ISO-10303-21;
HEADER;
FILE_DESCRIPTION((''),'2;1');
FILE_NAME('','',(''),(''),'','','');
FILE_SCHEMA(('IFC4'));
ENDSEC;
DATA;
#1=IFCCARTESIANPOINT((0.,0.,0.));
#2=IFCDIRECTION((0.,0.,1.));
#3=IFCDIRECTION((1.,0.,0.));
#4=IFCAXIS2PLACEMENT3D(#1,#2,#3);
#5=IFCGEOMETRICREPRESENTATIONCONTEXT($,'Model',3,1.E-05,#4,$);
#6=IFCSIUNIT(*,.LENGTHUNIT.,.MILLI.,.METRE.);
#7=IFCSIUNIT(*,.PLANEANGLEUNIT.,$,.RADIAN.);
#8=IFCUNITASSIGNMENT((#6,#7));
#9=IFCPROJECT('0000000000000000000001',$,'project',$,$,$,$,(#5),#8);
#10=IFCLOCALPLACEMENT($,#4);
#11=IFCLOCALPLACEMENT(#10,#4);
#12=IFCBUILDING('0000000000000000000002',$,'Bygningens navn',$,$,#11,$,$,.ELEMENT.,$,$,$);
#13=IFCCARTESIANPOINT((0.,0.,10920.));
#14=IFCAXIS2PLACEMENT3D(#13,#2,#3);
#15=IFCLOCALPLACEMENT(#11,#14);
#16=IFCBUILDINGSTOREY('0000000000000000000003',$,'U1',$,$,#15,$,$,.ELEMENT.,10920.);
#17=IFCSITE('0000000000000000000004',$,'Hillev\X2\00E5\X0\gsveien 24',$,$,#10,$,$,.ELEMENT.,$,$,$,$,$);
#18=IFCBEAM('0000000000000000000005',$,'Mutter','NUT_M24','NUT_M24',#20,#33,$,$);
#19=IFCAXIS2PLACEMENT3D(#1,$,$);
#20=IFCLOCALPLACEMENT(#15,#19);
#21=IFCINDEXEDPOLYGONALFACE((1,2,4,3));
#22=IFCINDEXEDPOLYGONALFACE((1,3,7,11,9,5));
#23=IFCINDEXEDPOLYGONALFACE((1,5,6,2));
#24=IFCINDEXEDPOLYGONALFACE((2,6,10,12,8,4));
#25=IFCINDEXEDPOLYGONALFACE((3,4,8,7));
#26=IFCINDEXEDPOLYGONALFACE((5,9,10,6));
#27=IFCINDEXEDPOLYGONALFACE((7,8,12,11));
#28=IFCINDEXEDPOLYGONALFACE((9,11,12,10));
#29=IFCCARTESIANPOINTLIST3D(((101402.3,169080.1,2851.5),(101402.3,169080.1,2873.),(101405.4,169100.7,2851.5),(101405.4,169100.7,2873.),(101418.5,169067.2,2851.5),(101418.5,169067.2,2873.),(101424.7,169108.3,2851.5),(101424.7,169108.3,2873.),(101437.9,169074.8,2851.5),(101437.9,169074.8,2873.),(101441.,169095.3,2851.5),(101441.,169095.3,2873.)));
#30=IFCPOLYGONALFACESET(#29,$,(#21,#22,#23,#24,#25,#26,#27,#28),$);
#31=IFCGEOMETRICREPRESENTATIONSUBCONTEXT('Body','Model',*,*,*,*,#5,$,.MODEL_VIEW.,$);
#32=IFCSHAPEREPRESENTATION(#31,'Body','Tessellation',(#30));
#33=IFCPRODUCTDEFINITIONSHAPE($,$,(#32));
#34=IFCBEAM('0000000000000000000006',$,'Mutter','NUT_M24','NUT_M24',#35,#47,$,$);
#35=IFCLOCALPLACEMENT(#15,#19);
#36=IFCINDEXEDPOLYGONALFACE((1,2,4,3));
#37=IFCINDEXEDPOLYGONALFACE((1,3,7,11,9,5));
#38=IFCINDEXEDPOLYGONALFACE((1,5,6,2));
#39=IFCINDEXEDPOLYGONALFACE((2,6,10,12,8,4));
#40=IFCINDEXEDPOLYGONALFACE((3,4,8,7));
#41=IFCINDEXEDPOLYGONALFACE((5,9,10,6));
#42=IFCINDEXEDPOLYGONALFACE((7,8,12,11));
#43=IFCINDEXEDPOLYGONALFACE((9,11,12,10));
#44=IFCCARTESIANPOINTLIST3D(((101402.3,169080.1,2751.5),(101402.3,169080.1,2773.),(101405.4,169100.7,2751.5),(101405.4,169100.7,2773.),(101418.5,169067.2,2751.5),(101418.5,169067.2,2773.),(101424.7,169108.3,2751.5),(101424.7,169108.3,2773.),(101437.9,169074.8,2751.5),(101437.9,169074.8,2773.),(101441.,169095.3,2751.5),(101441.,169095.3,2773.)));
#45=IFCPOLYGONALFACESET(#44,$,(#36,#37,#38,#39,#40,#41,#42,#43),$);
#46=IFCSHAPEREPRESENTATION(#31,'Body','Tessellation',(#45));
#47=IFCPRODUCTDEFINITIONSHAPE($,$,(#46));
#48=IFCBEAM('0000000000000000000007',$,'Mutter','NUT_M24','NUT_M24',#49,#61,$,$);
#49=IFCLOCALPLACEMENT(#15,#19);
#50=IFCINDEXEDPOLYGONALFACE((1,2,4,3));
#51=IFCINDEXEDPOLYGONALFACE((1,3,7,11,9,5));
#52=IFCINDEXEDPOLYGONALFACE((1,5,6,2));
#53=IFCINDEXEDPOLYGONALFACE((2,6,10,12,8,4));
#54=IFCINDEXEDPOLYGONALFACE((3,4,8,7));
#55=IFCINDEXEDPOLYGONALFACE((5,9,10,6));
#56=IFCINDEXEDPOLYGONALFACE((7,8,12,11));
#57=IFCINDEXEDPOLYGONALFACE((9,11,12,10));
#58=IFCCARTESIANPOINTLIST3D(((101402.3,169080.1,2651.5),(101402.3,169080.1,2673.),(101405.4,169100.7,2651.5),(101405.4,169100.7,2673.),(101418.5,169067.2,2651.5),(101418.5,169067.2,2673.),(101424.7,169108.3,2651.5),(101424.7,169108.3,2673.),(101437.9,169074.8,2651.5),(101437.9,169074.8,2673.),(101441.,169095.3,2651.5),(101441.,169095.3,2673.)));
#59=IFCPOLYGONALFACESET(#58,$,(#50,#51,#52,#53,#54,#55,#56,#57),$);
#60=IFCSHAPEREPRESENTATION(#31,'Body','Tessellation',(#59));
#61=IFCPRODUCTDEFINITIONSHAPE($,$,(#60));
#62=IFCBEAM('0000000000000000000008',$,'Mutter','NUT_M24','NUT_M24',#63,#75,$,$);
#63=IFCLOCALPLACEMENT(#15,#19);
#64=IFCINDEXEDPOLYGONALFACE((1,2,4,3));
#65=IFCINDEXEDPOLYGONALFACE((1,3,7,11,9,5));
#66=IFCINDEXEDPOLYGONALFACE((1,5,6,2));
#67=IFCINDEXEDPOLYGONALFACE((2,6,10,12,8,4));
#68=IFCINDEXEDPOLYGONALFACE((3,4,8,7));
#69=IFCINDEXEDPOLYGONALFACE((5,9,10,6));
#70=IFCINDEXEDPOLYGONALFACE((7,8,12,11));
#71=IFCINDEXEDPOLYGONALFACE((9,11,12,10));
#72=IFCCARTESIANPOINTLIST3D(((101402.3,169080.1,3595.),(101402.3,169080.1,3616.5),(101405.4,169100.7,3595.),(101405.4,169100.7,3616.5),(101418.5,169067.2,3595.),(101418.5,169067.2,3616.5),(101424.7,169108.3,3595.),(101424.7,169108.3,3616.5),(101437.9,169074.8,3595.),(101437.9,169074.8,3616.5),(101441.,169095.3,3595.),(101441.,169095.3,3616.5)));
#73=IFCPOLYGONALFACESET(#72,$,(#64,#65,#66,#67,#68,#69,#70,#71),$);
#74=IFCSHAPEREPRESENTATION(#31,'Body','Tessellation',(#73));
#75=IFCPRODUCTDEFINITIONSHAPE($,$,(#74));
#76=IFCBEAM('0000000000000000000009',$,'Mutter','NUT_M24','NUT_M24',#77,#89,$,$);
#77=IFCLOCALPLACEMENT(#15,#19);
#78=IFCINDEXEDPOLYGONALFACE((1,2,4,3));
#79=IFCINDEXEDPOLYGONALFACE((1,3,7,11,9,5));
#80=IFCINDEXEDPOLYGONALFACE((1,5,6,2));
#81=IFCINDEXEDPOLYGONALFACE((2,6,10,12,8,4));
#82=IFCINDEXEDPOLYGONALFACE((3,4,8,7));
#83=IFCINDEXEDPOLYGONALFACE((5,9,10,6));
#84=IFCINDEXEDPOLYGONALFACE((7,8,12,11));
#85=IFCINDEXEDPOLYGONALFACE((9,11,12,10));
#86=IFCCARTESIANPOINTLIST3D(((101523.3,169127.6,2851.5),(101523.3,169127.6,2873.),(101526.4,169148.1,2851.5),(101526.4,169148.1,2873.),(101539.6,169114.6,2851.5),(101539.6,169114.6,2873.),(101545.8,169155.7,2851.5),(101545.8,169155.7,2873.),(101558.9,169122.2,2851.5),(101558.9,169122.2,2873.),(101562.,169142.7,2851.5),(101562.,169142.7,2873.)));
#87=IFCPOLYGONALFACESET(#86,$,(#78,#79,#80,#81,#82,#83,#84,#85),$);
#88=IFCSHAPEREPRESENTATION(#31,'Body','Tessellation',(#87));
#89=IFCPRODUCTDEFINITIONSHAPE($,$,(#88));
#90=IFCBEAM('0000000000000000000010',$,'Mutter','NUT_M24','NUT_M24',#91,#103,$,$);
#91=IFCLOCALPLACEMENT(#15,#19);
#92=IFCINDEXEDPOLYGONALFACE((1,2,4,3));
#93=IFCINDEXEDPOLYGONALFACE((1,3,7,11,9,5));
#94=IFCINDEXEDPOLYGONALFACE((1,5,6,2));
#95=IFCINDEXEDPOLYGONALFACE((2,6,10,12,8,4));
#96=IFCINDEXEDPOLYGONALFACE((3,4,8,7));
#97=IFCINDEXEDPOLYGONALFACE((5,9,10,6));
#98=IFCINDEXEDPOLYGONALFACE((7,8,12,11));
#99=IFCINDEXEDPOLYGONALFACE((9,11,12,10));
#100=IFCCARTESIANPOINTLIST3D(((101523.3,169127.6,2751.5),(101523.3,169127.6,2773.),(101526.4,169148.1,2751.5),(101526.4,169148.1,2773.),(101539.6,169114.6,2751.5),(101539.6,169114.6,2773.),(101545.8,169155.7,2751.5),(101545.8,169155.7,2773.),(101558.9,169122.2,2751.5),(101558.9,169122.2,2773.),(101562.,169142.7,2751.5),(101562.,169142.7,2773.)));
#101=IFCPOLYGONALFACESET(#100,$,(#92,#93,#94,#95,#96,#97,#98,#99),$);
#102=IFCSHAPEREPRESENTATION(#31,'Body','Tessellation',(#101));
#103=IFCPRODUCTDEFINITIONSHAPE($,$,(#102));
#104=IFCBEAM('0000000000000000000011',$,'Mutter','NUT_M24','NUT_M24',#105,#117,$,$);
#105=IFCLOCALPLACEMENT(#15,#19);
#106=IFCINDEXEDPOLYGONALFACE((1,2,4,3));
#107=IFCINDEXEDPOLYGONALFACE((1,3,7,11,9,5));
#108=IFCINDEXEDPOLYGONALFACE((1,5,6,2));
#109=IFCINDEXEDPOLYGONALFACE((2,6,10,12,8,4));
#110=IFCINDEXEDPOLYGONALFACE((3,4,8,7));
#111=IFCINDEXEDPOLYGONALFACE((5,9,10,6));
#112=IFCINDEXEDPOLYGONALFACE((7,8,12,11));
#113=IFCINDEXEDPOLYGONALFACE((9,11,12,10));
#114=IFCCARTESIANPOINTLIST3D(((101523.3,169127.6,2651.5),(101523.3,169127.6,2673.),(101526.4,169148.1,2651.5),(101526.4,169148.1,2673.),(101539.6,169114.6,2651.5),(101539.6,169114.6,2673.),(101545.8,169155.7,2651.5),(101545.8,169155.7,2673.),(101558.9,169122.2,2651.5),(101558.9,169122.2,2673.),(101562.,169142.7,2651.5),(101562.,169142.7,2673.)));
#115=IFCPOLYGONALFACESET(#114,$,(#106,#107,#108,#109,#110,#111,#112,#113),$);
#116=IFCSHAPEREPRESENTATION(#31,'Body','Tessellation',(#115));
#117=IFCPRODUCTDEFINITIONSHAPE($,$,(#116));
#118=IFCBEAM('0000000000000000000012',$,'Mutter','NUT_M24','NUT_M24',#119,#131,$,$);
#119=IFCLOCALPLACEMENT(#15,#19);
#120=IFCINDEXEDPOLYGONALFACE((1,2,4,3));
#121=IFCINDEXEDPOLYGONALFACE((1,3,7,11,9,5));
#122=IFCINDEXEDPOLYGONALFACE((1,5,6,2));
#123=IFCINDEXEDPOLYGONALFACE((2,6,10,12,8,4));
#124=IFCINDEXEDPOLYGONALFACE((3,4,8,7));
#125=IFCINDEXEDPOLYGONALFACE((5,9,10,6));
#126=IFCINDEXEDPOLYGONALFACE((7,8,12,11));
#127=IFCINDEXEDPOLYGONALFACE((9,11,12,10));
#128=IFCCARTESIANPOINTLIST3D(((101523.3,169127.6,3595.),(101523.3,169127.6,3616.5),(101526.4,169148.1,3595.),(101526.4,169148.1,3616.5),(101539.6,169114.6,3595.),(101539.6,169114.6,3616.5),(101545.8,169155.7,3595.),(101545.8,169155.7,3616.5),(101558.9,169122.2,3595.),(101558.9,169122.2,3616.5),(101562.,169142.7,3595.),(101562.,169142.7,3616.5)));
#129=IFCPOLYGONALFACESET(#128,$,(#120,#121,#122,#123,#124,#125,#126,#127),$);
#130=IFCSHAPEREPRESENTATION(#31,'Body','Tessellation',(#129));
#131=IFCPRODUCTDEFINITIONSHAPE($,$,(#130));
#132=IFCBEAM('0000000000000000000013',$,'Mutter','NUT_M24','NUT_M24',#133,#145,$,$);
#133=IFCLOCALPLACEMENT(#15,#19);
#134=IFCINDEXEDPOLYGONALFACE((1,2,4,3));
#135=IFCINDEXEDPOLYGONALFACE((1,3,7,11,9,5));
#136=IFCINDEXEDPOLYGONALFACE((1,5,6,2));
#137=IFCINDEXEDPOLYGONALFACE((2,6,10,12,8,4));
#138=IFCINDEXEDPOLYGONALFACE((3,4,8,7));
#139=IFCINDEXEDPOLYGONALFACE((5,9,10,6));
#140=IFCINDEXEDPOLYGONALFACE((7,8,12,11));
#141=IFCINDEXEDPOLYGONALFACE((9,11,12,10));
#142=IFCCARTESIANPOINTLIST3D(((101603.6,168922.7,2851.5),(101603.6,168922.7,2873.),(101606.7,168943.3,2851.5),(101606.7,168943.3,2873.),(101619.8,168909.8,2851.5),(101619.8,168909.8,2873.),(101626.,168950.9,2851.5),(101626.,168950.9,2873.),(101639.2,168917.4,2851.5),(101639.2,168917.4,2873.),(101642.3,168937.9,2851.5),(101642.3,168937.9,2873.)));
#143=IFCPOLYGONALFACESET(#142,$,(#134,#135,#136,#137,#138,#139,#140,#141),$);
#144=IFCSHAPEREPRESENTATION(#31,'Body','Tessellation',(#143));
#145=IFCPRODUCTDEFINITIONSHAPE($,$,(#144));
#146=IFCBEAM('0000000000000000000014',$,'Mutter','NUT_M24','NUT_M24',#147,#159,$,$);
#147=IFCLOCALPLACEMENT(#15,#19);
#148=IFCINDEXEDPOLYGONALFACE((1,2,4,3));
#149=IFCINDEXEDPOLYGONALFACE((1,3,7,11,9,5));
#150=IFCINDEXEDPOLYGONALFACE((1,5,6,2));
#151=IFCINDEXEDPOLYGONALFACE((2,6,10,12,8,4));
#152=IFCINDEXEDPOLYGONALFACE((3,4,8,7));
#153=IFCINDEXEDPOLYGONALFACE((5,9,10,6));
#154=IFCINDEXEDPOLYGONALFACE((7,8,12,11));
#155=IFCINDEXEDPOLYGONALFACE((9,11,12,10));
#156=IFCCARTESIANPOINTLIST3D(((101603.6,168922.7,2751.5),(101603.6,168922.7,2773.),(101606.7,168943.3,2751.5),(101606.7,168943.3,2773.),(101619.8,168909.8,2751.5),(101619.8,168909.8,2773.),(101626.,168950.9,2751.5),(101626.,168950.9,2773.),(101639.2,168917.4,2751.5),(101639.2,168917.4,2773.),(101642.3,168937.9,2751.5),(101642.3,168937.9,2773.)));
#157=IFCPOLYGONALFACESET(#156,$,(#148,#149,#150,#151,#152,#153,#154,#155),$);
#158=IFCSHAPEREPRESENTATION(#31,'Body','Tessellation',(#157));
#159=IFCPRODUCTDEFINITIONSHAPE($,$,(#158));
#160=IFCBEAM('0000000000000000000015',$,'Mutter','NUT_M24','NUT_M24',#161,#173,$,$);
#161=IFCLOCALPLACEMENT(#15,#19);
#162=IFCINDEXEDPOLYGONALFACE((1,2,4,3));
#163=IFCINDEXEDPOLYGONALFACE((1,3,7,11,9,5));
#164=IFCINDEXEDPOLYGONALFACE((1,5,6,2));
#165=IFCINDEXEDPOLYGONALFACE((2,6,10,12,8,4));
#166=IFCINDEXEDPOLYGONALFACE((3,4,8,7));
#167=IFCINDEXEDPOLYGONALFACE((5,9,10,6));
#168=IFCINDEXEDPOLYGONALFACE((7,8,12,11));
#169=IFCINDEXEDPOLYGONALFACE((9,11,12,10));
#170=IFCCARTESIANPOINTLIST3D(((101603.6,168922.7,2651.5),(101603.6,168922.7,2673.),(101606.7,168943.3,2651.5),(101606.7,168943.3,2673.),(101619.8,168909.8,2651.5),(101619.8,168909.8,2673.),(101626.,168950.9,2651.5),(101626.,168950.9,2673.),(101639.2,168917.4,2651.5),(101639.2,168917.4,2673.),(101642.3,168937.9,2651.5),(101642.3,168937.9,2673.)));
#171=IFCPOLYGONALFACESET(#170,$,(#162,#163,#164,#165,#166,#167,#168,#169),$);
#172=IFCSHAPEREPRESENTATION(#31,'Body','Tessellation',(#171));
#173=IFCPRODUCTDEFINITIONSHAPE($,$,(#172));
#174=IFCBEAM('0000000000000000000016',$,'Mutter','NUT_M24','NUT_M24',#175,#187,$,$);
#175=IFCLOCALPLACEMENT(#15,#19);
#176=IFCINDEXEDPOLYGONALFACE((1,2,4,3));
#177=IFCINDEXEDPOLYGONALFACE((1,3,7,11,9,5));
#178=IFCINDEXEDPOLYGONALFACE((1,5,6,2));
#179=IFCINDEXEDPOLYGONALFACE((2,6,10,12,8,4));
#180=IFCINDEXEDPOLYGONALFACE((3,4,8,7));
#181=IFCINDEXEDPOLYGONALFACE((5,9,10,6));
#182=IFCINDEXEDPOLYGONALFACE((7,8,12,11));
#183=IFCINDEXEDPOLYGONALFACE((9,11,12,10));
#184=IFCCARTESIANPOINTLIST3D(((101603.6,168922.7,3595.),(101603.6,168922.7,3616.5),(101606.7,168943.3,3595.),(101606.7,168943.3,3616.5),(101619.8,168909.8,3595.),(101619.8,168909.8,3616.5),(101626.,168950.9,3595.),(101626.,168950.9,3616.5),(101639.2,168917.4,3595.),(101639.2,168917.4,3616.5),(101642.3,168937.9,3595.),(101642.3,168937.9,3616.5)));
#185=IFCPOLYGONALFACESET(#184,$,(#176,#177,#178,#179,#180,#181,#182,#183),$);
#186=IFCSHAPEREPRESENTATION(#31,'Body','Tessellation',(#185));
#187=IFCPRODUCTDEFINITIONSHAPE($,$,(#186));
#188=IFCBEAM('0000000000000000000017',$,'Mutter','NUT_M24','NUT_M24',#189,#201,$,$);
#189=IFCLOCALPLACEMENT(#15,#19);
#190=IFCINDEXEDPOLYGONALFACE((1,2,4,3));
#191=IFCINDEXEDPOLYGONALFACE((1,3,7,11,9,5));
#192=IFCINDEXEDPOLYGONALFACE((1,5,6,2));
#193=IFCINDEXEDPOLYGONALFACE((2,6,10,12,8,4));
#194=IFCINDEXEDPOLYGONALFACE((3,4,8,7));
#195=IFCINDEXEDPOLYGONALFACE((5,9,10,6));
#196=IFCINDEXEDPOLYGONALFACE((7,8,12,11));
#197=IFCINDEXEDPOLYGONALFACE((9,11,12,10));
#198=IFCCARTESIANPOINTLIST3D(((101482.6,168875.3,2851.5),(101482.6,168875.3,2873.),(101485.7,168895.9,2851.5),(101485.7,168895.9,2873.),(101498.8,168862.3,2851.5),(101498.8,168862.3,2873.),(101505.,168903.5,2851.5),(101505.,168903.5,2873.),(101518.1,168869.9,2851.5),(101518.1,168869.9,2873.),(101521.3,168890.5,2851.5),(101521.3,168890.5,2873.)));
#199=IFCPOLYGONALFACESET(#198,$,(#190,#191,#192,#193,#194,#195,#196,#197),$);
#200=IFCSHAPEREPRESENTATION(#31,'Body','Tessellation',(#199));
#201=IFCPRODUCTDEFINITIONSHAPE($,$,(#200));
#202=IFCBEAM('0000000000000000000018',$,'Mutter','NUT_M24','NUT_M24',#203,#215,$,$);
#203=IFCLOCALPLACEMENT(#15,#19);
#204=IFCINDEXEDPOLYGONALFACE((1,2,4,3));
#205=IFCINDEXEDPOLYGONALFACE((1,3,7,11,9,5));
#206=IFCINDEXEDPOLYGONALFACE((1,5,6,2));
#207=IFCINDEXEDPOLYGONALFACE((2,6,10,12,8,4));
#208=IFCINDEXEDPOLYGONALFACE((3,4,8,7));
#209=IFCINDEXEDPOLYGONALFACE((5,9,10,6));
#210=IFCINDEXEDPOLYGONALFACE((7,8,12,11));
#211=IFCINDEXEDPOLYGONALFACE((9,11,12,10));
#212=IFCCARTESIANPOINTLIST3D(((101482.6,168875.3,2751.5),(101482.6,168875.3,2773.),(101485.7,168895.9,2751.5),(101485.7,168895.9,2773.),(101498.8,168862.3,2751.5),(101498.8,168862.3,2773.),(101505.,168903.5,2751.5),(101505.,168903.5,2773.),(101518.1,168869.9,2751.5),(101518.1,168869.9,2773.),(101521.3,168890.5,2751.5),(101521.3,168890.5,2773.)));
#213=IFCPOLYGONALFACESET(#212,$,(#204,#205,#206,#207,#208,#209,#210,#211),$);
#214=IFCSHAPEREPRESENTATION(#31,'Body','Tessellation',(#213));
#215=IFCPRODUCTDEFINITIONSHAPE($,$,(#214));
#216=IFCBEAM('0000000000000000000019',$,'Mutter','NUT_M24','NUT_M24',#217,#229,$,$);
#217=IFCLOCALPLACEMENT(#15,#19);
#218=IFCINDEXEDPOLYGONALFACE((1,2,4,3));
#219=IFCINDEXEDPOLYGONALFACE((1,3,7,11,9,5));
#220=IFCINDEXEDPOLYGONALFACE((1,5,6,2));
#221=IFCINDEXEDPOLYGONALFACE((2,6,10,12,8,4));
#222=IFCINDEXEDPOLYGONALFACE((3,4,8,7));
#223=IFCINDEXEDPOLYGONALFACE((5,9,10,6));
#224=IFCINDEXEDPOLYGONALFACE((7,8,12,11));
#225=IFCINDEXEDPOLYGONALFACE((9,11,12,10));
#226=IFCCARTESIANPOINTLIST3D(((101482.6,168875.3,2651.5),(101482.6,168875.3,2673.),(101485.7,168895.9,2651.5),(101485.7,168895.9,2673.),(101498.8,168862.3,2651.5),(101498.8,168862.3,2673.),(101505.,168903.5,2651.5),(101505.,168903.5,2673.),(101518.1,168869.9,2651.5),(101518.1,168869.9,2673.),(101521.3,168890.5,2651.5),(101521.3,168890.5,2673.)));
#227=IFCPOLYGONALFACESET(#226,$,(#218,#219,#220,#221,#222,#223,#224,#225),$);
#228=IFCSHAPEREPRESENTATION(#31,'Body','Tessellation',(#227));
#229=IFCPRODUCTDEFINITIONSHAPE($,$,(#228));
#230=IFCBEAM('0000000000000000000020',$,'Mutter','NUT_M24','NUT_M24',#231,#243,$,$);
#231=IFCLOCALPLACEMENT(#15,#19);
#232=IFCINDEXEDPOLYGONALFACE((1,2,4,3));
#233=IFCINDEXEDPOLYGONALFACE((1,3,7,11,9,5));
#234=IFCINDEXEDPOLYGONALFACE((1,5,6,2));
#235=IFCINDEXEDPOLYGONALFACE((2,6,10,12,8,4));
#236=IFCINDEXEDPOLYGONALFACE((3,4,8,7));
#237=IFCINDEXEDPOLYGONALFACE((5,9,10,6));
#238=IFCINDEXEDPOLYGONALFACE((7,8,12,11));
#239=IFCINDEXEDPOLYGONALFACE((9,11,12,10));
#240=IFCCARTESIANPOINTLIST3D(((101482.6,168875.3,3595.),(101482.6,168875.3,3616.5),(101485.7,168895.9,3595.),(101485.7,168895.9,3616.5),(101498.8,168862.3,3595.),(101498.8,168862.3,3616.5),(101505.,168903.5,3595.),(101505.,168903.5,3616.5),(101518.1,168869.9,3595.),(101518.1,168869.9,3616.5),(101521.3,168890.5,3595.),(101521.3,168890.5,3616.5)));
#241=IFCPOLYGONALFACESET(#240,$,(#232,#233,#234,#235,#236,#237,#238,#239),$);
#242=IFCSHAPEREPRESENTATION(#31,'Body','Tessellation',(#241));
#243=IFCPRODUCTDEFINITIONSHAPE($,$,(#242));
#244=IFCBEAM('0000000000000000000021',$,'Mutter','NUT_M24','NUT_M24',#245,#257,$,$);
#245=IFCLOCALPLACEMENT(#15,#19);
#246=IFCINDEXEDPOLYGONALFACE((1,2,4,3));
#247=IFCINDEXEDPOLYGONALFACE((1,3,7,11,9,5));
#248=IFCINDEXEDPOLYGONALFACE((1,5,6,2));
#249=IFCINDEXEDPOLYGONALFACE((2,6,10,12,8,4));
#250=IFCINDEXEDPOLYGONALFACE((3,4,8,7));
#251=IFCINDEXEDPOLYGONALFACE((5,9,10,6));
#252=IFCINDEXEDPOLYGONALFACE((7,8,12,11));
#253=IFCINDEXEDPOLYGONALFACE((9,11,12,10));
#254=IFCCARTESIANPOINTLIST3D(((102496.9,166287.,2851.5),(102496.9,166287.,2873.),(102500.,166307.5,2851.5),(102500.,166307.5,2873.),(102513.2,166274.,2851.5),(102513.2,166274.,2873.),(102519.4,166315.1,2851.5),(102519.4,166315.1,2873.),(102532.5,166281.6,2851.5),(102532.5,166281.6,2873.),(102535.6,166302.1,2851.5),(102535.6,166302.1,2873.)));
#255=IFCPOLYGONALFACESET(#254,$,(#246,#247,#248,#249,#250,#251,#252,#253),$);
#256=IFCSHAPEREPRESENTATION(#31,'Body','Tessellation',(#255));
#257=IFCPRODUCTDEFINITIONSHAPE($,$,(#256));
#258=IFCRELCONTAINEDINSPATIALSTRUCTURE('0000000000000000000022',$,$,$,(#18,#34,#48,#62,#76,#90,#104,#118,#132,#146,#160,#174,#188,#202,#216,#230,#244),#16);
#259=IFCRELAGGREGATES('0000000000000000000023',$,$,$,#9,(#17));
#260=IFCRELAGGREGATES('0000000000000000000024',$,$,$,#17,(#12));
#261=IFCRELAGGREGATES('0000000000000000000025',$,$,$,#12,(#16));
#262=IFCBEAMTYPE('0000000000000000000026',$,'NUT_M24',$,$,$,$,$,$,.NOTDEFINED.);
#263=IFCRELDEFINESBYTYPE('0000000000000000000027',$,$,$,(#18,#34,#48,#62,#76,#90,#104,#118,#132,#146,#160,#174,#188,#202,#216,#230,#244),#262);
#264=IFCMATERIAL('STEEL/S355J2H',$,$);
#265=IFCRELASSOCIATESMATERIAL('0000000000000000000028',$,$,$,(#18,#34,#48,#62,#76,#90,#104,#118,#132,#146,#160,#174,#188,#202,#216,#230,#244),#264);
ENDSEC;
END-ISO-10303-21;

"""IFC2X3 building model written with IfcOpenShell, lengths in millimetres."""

from ifc_helpers import new_model, si_unit, frame, origin_with_axes, place, context, subcontext, project, spatial, polyline, outline, extrude, material, type_object, element, save


model = new_model("IFC2X3")

# Units and contexts
model_context = context("Model", 3, precision=1e-05, world=origin_with_axes())
body_context = subcontext(model_context, "Body", "Model", "MODEL_VIEW")
ifc_project = project(units=[si_unit("LENGTHUNIT", "METRE", prefix="MILLI"), si_unit("PLANEANGLEUNIT", "RADIAN")], contexts=[model_context])

# Site, building, storey
site_placement = place(None, origin_with_axes())
site = spatial("IfcSite", under=ifc_project, at=site_placement, Name="Hillevågsveien 24", CompositionType="ELEMENT")
building_placement = place(site_placement, origin_with_axes())
building = spatial("IfcBuilding", under=site, at=building_placement, Name="Bygningens navn", CompositionType="ELEMENT")
storey_placement = place(building_placement, frame((0.0, 0.0, 10920.0), z_axis=(0.0, 0.0, 1.0), x_axis=(1.0, 0.0, 0.0)))
storey = spatial("IfcBuildingStorey", under=building, at=storey_placement, Name="U1", CompositionType="ELEMENT", Elevation=10920.0)

# Beams
ifc_material_1 = material(Name="STEEL/S355J2H")
beam_type_1 = type_object("IfcBeamType", Name="NUT_M24", PredefinedType="NOTDEFINED")
for number, where, z_axis, x_axis, name in (
    (1, (101421.6, 169087.7, 2873.0), (-0.364877, 0.931056, 0.0), (0.0, 0.0, -1.0), "Mutter"),
    (2, (101421.6, 169087.7, 2773.0), (-0.364877, 0.931056, 0.0), (0.0, 0.0, -1.0), "Mutter"),
    (3, (101421.6, 169087.7, 2673.0), (-0.364877, 0.931056, 0.0), (0.0, 0.0, -1.0), "Mutter"),
    (4, (101421.6, 169087.7, 3616.5), (-0.364877, 0.931056, 0.0), (0.0, 0.0, -1.0), "Mutter"),
    (5, (101542.7, 169135.2, 2873.0), (-0.364877, 0.931056, 0.0), (0.0, 0.0, -1.0), "Mutter"),
    (6, (101542.7, 169135.2, 2773.0), (-0.364877, 0.931056, 0.0), (0.0, 0.0, -1.0), "Mutter"),
    (7, (101542.7, 169135.2, 2673.0), (-0.364877, 0.931056, 0.0), (0.0, 0.0, -1.0), "Mutter"),
    (8, (101542.7, 169135.2, 3616.5), (-0.364877, 0.931056, 0.0), (0.0, 0.0, -1.0), "Mutter"),
    (9, (101622.9, 168930.3, 2873.0), (-0.364877, 0.931056, 0.0), (0.0, 0.0, -1.0), "Mutter"),
    (10, (101622.9, 168930.3, 2773.0), (-0.364877, 0.931056, 0.0), (0.0, 0.0, -1.0), "Mutter"),
    (11, (101622.9, 168930.3, 2673.0), (-0.364877, 0.931056, 0.0), (0.0, 0.0, -1.0), "Mutter"),
    (12, (101622.9, 168930.3, 3616.5), (-0.364877, 0.931056, 0.0), (0.0, 0.0, -1.0), "Mutter"),
    (13, (101501.9, 168882.9, 2873.0), (-0.364877, 0.931056, 0.0), (0.0, 0.0, -1.0), "Mutter"),
    (14, (101501.9, 168882.9, 2773.0), (-0.364877, 0.931056, 0.0), (0.0, 0.0, -1.0), "Mutter"),
    (15, (101501.9, 168882.9, 2673.0), (-0.364877, 0.931056, 0.0), (0.0, 0.0, -1.0), "Mutter"),
    (16, (101501.9, 168882.9, 3616.5), (-0.364877, 0.931056, 0.0), (0.0, 0.0, -1.0), "Mutter"),
    (17, (102516.3, 166294.6, 2873.0), (-0.364877, 0.931056, 0.0), (0.0, 0.0, -1.0), "Mutter"),
):
    element("IfcBeam", number, at=place(storey_placement, frame(where, z_axis=z_axis, x_axis=x_axis)), inside=storey, type_object=beam_type_1, material=ifc_material_1, Name=name, Description="NUT_M24", ObjectType="NUT_M24", context=body_context, shape_type="SweptSolid", body=[
        extrude(outline(polyline([(-10.4, 18.0), (10.4, 18.0), (20.8, 0.0), (10.4, -18.0), (-10.4, -18.0), (-20.8, 0.0), (-10.4, 18.0)])), frame((21.5, 0.0, 0.0), z_axis=(-1.0, 0.0, 0.0), x_axis=(0.0, -1.0, 0.0)), (0.0, 0.0, 1.0), 21.5),
    ])

save(model, "model.ifc")
